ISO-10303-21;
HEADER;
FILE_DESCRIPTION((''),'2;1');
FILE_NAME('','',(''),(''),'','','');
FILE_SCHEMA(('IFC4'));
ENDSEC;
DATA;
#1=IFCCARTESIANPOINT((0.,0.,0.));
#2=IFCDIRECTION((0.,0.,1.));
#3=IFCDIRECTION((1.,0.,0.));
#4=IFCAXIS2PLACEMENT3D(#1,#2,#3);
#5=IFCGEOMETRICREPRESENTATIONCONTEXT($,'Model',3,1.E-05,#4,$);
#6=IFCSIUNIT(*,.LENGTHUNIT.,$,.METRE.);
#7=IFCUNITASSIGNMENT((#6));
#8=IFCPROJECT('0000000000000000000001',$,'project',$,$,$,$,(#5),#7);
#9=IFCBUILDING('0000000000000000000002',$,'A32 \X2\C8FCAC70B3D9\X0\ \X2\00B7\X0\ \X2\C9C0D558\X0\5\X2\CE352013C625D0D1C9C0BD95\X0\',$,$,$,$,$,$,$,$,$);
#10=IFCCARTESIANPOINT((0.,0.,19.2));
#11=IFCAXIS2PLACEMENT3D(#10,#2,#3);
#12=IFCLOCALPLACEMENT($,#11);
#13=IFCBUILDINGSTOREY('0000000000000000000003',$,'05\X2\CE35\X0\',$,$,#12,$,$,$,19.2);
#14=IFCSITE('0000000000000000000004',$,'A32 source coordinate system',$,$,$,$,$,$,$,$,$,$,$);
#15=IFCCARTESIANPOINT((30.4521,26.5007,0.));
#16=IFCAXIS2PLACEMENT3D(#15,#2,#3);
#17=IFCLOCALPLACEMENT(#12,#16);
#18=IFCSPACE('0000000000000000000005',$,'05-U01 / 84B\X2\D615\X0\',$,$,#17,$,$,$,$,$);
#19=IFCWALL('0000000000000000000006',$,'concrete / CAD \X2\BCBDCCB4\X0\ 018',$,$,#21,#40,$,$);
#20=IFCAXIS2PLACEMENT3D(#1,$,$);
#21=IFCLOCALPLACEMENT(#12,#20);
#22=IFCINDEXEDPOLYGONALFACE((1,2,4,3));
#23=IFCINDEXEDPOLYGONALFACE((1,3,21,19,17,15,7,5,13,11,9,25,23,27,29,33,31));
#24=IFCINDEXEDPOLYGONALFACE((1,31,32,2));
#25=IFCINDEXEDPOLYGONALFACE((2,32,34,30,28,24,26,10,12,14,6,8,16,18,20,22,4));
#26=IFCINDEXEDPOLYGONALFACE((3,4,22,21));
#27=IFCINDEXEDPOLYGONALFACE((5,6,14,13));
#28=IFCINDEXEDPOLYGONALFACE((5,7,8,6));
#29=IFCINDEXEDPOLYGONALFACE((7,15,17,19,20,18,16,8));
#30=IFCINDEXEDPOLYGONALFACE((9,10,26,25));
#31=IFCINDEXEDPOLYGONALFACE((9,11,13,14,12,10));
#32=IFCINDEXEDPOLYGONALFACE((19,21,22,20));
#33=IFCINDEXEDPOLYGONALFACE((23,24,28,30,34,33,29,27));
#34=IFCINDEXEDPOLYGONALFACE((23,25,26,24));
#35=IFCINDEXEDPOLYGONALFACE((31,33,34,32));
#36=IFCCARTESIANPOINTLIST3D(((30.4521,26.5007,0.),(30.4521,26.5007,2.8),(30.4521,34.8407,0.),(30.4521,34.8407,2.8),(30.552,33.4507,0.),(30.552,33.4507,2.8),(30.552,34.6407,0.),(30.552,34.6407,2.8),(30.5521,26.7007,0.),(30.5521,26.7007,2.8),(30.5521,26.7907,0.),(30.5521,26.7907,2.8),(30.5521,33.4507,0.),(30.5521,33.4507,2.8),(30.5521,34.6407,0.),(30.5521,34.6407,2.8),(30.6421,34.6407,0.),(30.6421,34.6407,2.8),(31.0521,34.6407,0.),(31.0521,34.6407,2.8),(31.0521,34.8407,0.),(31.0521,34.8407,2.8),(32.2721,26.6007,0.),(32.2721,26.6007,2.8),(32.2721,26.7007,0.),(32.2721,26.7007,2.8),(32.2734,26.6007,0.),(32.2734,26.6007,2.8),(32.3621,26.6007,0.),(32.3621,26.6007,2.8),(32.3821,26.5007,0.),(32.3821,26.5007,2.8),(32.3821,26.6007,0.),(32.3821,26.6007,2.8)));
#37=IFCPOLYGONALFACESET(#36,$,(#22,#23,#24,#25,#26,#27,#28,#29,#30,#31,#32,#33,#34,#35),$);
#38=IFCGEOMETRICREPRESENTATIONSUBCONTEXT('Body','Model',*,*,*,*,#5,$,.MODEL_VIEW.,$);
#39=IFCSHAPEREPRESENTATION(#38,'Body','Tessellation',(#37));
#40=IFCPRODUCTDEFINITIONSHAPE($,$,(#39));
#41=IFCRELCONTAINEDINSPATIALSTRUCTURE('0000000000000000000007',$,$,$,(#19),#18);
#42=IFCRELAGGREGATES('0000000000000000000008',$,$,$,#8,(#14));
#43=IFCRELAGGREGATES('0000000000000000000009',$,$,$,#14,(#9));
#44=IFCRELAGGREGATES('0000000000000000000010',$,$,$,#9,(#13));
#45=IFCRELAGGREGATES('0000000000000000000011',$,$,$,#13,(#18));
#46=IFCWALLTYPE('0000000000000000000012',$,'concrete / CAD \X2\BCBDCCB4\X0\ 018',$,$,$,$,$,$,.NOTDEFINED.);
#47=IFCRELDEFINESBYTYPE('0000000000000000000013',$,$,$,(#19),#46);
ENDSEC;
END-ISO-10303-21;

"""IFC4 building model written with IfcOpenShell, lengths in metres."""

from ifc_helpers import new_model, si_unit, frame, origin, origin_with_axes, place, context, subcontext, project, spatial, polyline, outline, extrude, source, transform, mapped, type_object, type_shapes, element, save


model = new_model("IFC4")

# Units and contexts
model_context = context("Model", 3, precision=1e-05, world=origin_with_axes())
body_context = subcontext(model_context, "Body", "Model", "MODEL_VIEW")
ifc_project = project(units=[si_unit("LENGTHUNIT", "METRE")], contexts=[model_context])

# Site, building, storey, space
site = spatial("IfcSite", under=ifc_project, Name="A32 source coordinate system")
building = spatial("IfcBuilding", under=site, Name="A32 주거동 · 지하5층–옥탑지붕")
storey_placement = place(None, frame((0.0, 0.0, 19.2), z_axis=(0.0, 0.0, 1.0), x_axis=(1.0, 0.0, 0.0)))
storey = spatial("IfcBuildingStorey", under=building, at=storey_placement, Name="05층", Elevation=19.2)
space_1_placement = place(storey_placement, frame((30.4521, 26.5007, 0.0), z_axis=(0.0, 0.0, 1.0), x_axis=(1.0, 0.0, 0.0)))
space_1 = spatial("IfcSpace", under=storey, at=space_1_placement, Name="05-U01 / 84B형")

# Wall
wall_type_1 = type_object("IfcWallType", Name="concrete / CAD 벽체 018", PredefinedType="NOTDEFINED")
shared_shape_1 = source(origin(), body_context, "Body", "SweptSolid", [
    extrude(outline(polyline([(0.6, 8.34), (0.6, 8.14), (0.19, 8.14), (0.1, 8.14), (0.0999, 8.14), (0.0999, 6.95), (0.1, 6.95), (0.1, 0.29), (0.1, 0.2), (1.82, 0.2), (1.82, 0.1), (1.8213, 0.1), (1.91, 0.1), (1.93, 0.1), (1.93, 0.0), (0.0, 0.0), (0.0, 8.34), (-0.35, 8.34), (-0.35, 8.34), (0.6, 8.34)])), origin(), (0.0, 0.0, 1.0), 2.8),
])
type_shapes(wall_type_1, [shared_shape_1])
wall_1_placement = place(space_1_placement, origin_with_axes())
element("IfcWall", 1, at=wall_1_placement, inside=space_1, type_object=wall_type_1, Name="concrete / CAD 벽체 018", context=body_context, shape_type="MappedRepresentation", body=[
    mapped(shared_shape_1, transform((0.0, 0.0, 0.0), scale=1.0)),
])

save(model, "model.ifc")
